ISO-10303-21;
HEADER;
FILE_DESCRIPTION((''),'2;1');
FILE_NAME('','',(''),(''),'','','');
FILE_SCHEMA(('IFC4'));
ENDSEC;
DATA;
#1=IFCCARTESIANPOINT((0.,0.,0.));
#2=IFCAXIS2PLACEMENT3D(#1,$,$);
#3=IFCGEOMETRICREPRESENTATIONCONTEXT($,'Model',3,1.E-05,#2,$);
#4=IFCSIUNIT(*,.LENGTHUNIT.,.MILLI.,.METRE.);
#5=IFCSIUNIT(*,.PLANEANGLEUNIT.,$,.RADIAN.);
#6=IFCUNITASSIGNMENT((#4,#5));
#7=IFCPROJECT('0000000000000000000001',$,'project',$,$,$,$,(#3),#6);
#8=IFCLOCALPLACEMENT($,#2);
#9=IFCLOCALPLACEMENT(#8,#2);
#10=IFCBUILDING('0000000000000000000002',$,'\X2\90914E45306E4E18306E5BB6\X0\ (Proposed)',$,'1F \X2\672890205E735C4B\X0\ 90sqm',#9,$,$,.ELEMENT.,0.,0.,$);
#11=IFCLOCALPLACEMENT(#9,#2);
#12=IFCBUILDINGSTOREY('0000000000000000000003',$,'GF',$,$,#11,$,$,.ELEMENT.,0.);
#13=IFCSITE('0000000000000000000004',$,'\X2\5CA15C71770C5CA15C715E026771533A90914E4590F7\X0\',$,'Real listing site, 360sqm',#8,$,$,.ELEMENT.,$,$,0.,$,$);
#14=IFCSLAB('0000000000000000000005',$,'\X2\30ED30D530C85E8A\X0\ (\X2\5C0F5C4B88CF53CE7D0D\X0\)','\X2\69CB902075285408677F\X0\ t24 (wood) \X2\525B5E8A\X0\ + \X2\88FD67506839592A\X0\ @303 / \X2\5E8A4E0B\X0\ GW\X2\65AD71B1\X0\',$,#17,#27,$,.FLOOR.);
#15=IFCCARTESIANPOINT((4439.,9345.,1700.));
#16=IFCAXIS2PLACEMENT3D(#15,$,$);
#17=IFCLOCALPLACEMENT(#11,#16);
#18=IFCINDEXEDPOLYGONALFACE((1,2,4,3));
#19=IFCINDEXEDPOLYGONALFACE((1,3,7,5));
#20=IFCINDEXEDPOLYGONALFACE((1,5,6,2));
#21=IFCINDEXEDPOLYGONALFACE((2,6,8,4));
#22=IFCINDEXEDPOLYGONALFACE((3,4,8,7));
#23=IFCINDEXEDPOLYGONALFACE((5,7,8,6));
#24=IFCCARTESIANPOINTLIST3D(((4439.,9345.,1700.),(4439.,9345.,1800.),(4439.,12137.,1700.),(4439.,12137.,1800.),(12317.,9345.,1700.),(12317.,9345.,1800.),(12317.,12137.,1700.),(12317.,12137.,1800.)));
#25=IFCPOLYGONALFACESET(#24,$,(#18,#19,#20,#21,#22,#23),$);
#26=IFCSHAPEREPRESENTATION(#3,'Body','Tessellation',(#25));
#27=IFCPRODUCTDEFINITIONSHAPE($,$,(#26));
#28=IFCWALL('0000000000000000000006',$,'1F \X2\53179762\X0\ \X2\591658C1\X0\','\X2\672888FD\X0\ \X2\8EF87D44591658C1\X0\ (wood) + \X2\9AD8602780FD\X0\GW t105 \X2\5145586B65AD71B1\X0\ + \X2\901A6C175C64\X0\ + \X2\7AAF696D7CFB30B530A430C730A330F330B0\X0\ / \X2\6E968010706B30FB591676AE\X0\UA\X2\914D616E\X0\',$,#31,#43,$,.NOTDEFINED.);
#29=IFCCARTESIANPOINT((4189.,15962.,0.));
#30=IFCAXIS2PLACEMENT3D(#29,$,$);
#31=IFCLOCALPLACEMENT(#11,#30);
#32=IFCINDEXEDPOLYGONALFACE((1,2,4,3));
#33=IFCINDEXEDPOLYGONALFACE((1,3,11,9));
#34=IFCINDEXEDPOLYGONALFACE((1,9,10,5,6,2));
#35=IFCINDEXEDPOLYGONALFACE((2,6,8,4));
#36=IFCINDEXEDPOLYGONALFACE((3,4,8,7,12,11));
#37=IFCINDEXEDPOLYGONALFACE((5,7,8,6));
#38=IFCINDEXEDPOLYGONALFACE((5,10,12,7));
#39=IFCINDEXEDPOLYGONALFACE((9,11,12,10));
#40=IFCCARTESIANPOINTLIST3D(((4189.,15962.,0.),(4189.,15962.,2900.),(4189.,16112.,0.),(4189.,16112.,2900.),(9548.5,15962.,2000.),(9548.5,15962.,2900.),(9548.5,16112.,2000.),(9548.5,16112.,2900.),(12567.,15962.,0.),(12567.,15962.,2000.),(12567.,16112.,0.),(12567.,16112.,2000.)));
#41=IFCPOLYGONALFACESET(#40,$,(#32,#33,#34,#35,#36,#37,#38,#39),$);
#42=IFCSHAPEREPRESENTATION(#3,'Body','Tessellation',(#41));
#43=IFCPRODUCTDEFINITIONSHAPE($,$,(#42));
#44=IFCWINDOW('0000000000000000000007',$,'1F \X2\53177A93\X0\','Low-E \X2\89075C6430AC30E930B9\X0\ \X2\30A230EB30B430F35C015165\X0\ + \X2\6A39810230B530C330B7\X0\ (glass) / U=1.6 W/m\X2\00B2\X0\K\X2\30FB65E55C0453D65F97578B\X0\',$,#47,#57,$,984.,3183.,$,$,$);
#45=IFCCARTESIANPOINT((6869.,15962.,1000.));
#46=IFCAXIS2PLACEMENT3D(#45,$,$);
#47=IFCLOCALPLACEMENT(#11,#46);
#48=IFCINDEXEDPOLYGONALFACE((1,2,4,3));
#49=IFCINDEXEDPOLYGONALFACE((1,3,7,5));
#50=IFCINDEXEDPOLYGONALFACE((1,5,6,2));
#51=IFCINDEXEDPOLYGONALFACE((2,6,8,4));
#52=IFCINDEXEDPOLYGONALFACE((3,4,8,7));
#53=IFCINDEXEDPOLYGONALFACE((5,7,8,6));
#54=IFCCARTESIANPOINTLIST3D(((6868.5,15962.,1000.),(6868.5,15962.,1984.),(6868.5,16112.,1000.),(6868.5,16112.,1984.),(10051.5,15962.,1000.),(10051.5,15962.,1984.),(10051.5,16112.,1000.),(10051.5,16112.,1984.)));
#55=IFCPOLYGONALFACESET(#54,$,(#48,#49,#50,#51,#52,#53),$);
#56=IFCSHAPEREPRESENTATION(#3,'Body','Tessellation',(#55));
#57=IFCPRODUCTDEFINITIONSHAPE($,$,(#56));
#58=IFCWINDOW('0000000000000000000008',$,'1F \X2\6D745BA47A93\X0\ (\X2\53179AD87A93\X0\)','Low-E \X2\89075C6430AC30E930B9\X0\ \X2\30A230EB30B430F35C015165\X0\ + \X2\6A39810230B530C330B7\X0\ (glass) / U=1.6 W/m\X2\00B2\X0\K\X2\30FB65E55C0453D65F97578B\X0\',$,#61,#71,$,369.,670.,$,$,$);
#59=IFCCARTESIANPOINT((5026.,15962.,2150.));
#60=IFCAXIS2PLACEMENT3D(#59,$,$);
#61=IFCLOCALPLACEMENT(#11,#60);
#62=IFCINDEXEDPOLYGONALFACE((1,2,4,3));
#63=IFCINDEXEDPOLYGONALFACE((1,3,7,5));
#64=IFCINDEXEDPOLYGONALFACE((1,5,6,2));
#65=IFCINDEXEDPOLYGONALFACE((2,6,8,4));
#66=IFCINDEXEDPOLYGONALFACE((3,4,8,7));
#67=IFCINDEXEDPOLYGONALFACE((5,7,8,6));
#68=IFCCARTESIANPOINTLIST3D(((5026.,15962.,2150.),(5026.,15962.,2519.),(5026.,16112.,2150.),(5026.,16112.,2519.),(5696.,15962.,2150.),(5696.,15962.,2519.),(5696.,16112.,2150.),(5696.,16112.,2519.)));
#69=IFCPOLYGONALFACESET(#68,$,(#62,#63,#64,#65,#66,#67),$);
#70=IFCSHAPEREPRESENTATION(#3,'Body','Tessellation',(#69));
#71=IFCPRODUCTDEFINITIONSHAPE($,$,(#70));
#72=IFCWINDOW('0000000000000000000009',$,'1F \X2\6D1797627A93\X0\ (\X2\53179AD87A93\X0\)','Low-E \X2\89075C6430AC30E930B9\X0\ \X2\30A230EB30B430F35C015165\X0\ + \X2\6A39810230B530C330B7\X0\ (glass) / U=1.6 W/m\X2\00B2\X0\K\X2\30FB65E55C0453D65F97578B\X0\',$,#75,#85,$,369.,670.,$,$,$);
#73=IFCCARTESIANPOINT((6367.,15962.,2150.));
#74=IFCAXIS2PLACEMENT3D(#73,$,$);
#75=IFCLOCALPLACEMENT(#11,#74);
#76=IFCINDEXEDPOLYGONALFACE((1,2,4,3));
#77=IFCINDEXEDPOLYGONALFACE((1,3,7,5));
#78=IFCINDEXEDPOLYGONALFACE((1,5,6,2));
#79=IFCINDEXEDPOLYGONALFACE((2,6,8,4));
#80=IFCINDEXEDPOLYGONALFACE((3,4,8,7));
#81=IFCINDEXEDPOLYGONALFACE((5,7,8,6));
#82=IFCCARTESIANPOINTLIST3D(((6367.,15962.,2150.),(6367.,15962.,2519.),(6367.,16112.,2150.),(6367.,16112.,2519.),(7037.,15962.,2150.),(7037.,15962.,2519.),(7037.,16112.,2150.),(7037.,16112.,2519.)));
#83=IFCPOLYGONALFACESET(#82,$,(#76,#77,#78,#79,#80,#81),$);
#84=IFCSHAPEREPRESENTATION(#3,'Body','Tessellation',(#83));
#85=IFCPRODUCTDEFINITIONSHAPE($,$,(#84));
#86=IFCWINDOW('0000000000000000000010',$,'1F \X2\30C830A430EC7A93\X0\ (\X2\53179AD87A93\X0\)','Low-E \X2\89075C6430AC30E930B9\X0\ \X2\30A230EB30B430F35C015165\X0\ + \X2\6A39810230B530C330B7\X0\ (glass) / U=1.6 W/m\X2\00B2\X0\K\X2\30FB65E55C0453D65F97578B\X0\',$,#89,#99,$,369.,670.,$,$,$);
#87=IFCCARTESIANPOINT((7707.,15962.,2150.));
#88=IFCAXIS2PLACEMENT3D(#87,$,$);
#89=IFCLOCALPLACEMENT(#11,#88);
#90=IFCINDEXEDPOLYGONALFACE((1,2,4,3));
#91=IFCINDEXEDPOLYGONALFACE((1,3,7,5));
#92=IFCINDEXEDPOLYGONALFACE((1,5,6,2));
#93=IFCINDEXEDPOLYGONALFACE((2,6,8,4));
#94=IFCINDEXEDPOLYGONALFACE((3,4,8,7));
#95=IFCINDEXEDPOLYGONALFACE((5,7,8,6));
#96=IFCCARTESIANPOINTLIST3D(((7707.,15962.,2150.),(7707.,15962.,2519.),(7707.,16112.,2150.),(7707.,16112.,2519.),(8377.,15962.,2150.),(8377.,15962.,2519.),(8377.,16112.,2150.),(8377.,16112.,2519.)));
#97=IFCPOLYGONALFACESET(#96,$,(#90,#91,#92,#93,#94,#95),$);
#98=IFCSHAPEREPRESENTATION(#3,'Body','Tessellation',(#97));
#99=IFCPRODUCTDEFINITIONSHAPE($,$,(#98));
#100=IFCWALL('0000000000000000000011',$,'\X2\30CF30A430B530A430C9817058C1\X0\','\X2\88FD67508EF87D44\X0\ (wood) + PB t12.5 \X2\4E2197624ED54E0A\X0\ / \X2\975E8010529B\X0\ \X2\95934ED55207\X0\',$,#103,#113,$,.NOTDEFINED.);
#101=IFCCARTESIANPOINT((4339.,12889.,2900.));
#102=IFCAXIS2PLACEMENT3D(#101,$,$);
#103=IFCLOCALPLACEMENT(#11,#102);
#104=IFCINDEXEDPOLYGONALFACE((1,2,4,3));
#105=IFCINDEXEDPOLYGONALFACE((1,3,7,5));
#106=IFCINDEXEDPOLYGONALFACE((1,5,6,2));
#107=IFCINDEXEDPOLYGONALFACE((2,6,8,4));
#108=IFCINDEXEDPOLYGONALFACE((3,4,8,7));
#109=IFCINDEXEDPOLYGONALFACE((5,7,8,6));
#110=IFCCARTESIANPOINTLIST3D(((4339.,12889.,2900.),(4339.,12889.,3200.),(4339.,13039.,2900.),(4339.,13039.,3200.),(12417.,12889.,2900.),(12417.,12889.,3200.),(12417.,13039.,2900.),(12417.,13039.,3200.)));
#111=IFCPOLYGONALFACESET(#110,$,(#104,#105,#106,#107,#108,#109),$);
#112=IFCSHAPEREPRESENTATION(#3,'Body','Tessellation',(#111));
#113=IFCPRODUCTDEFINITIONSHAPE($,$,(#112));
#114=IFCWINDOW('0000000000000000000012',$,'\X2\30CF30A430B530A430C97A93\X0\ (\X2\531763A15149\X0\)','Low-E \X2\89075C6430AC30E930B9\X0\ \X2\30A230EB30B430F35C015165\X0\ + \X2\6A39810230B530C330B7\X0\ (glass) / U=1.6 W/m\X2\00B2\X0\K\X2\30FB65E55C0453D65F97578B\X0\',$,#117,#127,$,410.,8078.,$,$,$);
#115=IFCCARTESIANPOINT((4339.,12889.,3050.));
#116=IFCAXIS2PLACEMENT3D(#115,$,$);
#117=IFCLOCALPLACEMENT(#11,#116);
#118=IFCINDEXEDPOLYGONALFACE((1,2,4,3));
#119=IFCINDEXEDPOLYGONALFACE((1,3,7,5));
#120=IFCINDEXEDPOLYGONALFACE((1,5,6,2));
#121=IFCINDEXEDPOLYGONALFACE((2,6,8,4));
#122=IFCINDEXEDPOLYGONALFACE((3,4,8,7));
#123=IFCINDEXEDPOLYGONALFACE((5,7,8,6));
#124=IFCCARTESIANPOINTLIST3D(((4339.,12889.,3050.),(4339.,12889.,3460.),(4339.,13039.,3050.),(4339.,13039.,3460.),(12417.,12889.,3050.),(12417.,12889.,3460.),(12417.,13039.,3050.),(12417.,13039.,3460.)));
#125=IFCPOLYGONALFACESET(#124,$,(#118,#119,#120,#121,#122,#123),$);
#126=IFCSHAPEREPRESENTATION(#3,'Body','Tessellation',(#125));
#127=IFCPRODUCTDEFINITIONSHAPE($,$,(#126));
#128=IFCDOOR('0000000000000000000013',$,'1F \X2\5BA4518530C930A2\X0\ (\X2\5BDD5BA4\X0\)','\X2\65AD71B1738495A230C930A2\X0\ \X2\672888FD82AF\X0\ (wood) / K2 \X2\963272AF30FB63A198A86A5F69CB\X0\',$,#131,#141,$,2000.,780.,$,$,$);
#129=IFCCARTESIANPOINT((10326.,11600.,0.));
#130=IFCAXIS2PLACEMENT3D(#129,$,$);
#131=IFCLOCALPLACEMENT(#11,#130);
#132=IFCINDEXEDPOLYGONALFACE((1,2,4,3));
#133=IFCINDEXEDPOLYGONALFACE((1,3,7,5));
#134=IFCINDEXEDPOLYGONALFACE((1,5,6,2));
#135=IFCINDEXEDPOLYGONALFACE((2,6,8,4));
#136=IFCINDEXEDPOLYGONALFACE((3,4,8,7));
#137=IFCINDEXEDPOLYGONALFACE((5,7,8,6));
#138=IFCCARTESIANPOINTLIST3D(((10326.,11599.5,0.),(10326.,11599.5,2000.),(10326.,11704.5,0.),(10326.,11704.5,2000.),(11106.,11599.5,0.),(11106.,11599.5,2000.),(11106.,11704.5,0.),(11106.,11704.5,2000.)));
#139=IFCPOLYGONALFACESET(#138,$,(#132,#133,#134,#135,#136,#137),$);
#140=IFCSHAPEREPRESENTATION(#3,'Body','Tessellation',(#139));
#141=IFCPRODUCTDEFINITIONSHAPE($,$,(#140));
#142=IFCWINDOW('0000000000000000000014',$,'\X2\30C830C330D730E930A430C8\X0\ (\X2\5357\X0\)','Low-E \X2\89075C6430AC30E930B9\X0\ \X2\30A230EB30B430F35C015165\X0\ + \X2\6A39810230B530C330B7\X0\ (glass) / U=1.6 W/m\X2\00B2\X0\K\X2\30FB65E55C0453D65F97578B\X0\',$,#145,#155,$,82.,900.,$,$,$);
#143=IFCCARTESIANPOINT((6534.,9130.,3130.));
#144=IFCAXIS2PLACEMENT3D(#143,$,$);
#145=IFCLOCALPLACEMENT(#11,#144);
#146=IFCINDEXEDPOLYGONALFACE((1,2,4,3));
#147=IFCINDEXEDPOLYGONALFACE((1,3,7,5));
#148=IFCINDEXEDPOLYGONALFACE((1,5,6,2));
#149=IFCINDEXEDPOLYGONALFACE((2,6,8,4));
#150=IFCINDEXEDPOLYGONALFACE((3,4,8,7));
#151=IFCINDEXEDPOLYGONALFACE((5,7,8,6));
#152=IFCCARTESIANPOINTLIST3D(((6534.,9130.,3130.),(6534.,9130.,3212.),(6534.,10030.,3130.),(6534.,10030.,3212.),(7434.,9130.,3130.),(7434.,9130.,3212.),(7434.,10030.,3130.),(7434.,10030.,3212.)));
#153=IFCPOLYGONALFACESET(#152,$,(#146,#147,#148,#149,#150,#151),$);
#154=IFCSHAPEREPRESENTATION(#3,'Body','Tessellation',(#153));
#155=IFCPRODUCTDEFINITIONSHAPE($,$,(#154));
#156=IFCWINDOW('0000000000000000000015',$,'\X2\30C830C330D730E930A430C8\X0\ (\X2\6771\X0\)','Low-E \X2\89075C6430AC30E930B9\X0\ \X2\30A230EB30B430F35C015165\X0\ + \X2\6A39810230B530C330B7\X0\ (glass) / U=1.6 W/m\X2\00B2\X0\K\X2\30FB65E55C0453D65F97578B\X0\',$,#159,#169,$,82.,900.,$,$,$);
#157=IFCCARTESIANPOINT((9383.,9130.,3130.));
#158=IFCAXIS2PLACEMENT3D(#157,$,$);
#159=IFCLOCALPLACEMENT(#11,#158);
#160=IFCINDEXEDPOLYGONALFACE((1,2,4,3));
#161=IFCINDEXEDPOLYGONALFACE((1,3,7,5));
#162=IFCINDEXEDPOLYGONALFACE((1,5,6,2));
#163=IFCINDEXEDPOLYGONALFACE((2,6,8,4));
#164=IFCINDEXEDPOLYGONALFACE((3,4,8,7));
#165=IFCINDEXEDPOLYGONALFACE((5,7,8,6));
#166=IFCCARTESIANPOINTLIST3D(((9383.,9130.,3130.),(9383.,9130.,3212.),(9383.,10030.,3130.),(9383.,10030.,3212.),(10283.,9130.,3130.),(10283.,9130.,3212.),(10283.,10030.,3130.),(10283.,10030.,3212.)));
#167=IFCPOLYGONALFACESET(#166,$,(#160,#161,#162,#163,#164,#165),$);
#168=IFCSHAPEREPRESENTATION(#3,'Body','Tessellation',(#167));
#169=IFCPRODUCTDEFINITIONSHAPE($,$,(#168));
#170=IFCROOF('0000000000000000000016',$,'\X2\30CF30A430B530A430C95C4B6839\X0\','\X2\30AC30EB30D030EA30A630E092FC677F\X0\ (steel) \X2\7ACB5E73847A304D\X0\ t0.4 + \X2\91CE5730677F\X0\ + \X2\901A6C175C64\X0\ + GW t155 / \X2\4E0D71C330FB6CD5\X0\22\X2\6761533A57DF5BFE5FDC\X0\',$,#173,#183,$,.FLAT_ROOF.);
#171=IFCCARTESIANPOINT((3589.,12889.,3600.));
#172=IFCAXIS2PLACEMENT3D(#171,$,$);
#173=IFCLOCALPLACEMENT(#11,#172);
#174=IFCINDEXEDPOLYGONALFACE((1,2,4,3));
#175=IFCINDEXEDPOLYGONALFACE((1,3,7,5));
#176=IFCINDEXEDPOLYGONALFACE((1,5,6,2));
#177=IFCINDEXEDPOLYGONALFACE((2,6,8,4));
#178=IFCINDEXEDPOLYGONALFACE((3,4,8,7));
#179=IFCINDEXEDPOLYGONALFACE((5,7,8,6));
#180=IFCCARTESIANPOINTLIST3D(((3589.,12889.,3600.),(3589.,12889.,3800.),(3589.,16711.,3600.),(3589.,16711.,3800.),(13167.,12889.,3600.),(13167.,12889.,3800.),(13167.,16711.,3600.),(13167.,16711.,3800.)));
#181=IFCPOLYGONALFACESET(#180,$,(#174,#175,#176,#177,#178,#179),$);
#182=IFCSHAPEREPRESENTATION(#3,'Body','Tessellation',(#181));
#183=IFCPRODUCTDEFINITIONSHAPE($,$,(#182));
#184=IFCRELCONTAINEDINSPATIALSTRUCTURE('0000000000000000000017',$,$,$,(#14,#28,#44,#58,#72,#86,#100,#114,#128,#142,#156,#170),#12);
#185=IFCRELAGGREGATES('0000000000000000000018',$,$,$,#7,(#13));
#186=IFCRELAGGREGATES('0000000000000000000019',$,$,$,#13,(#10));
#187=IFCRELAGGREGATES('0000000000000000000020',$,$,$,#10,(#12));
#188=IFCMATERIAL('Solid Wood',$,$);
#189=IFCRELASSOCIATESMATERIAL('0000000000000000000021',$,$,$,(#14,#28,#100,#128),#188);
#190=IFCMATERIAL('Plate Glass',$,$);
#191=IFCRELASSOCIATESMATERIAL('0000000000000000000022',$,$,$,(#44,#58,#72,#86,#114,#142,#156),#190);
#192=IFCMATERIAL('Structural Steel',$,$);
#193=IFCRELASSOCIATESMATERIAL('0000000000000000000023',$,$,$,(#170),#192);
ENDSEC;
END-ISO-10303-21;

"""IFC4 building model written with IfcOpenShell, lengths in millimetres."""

from ifc_helpers import new_model, si_unit, frame, frame_2d, origin, place, context, project, spatial, rectangle, extrude, material, element, fill, save


model = new_model("IFC4")

# Units and contexts
model_context = context("Model", 3, precision=1e-05, world=origin())
ifc_project = project(units=[si_unit("LENGTHUNIT", "METRE", prefix="MILLI"), si_unit("PLANEANGLEUNIT", "RADIAN")], contexts=[model_context])

# Site, building, storey
site_placement = place(None, origin())
site = spatial("IfcSite", under=ifc_project, at=site_placement, Name="岡山県岡山市東区邑久郷", ObjectType="Real listing site, 360sqm", CompositionType="ELEMENT", RefElevation=0.0)
building_placement = place(site_placement, origin())
building = spatial("IfcBuilding", under=site, at=building_placement, Name="邑久の丘の家 (Proposed)", ObjectType="1F 木造平屋 90sqm", CompositionType="ELEMENT", ElevationOfRefHeight=0.0, ElevationOfTerrain=0.0)
storey_placement = place(building_placement, origin())
storey = spatial("IfcBuildingStorey", under=building, at=storey_placement, Name="GF", CompositionType="ELEMENT", Elevation=0.0)

# Slab
ifc_material_1 = material(Name="Solid Wood")
slab_placement = place(storey_placement, frame((4439.0, 9345.0, 1700.0)))
element("IfcSlab", 1, at=slab_placement, inside=storey, material=ifc_material_1, Name="ロフト床 (小屋裏収納)", Description="構造用合板 t24 (wood) 剛床 + 製材根太 @303 / 床下 GW断熱", PredefinedType="FLOOR", context=model_context, shape_type="SweptSolid", body=[
    extrude(rectangle(XDim=7878.0, YDim=2792.0, at=frame_2d((3939.0, 1396.0))), frame((4439.0, 9345.0, 1700.0)), (0.0, 0.0, 1.0), 100.0),
])

# Wall, openings, windows
wall_1_placement = place(storey_placement, frame((4189.0, 15962.0, 0.0)))
wall_1 = element("IfcWall", 2, at=wall_1_placement, inside=storey, material=ifc_material_1, Name="1F 北面 外壁", Description="木製 軸組外壁 (wood) + 高性能GW t105 充填断熱 + 通気層 + 窯業系サイディング / 準耐火・外皮UA配慮", PredefinedType="NOTDEFINED", context=model_context, shape_type="SweptSolid", body=[
    extrude(rectangle(XDim=8378.0, YDim=150.0, at=frame_2d((4189.0, 75.0))), frame((4189.0, 15962.0, 0.0)), (0.0, 0.0, 1.0), 2900.0),
])
opening_1_placement = place(storey_placement, frame((6869.0, 15962.0, 1000.0)))
opening_1 = element("IfcOpeningElement", 3, at=opening_1_placement, cuts=wall_1, PredefinedType="NOTDEFINED", context=model_context, shape_type="SweptSolid", body=[
    extrude(rectangle(XDim=3183.0, YDim=150.0, at=frame_2d((1591.0, 75.0))), frame((6869.0, 15962.0, 1000.0)), (0.0, 0.0, 1.0), 984.0),
])
opening_2_placement = place(storey_placement, frame((5026.0, 15962.0, 2150.0)))
opening_2 = element("IfcOpeningElement", 4, at=opening_2_placement, cuts=wall_1, PredefinedType="NOTDEFINED", context=model_context, shape_type="SweptSolid", body=[
    extrude(rectangle(XDim=670.0, YDim=150.0, at=frame_2d((335.0, 75.0))), frame((5026.0, 15962.0, 2150.0)), (0.0, 0.0, 1.0), 369.0),
])
opening_3_placement = place(storey_placement, frame((6367.0, 15962.0, 2150.0)))
opening_3 = element("IfcOpeningElement", 5, at=opening_3_placement, cuts=wall_1, PredefinedType="NOTDEFINED", context=model_context, shape_type="SweptSolid", body=[
    extrude(rectangle(XDim=670.0, YDim=150.0, at=frame_2d((335.0, 75.0))), frame((6367.0, 15962.0, 2150.0)), (0.0, 0.0, 1.0), 369.0),
])
opening_4_placement = place(storey_placement, frame((7707.0, 15962.0, 2150.0)))
opening_4 = element("IfcOpeningElement", 6, at=opening_4_placement, cuts=wall_1, PredefinedType="NOTDEFINED", context=model_context, shape_type="SweptSolid", body=[
    extrude(rectangle(XDim=670.0, YDim=150.0, at=frame_2d((335.0, 75.0))), frame((7707.0, 15962.0, 2150.0)), (0.0, 0.0, 1.0), 369.0),
])
ifc_material_2 = material(Name="Plate Glass")
window_1_placement = place(storey_placement, frame((6869.0, 15962.0, 1000.0)))
window_1 = element("IfcWindow", 7, at=window_1_placement, inside=storey, material=ifc_material_2, Name="1F 北窓", Description="Low-E 複層ガラス アルゴン封入 + 樹脂サッシ (glass) / U=1.6 W/m²K・日射取得型", OverallHeight=984.0, OverallWidth=3183.0, context=model_context, shape_type="SweptSolid", body=[
    extrude(rectangle(XDim=3183.0, YDim=150.0, at=frame_2d((1591.0, 75.0))), frame((6869.0, 15962.0, 1000.0)), (0.0, 0.0, 1.0), 984.0),
])
fill(opening_1, window_1)
window_2_placement = place(storey_placement, frame((5026.0, 15962.0, 2150.0)))
window_2 = element("IfcWindow", 8, at=window_2_placement, inside=storey, material=ifc_material_2, Name="1F 浴室窓 (北高窓)", Description="Low-E 複層ガラス アルゴン封入 + 樹脂サッシ (glass) / U=1.6 W/m²K・日射取得型", OverallHeight=369.0, OverallWidth=670.0, context=model_context, shape_type="SweptSolid", body=[
    extrude(rectangle(XDim=670.0, YDim=150.0, at=frame_2d((335.0, 75.0))), frame((5026.0, 15962.0, 2150.0)), (0.0, 0.0, 1.0), 369.0),
])
fill(opening_2, window_2)
window_3_placement = place(storey_placement, frame((6367.0, 15962.0, 2150.0)))
window_3 = element("IfcWindow", 9, at=window_3_placement, inside=storey, material=ifc_material_2, Name="1F 洗面窓 (北高窓)", Description="Low-E 複層ガラス アルゴン封入 + 樹脂サッシ (glass) / U=1.6 W/m²K・日射取得型", OverallHeight=369.0, OverallWidth=670.0, context=model_context, shape_type="SweptSolid", body=[
    extrude(rectangle(XDim=670.0, YDim=150.0, at=frame_2d((335.0, 75.0))), frame((6367.0, 15962.0, 2150.0)), (0.0, 0.0, 1.0), 369.0),
])
fill(opening_3, window_3)
window_4_placement = place(storey_placement, frame((7707.0, 15962.0, 2150.0)))
window_4 = element("IfcWindow", 10, at=window_4_placement, inside=storey, material=ifc_material_2, Name="1F トイレ窓 (北高窓)", Description="Low-E 複層ガラス アルゴン封入 + 樹脂サッシ (glass) / U=1.6 W/m²K・日射取得型", OverallHeight=369.0, OverallWidth=670.0, context=model_context, shape_type="SweptSolid", body=[
    extrude(rectangle(XDim=670.0, YDim=150.0, at=frame_2d((335.0, 75.0))), frame((7707.0, 15962.0, 2150.0)), (0.0, 0.0, 1.0), 369.0),
])
fill(opening_4, window_4)

# Wall, opening, window
wall_2_placement = place(storey_placement, frame((4339.0, 12889.0, 2900.0)))
wall_2 = element("IfcWall", 11, at=wall_2_placement, inside=storey, material=ifc_material_1, Name="ハイサイド腰壁", Description="製材軸組 (wood) + PB t12.5 両面仕上 / 非耐力 間仕切", PredefinedType="NOTDEFINED", context=model_context, shape_type="SweptSolid", body=[
    extrude(rectangle(XDim=8078.0, YDim=150.0, at=frame_2d((4039.0, 75.0))), frame((4339.0, 12889.0, 2900.0)), (0.0, 0.0, 1.0), 700.0),
])
opening_5_placement = place(storey_placement, frame((4339.0, 12889.0, 3050.0)))
opening_5 = element("IfcOpeningElement", 12, at=opening_5_placement, cuts=wall_2, PredefinedType="NOTDEFINED", context=model_context, shape_type="SweptSolid", body=[
    extrude(rectangle(XDim=8078.0, YDim=150.0, at=frame_2d((4039.0, 75.0))), frame((4339.0, 12889.0, 3050.0)), (0.0, 0.0, 1.0), 410.0),
])
window_5_placement = place(storey_placement, frame((4339.0, 12889.0, 3050.0)))
window_5 = element("IfcWindow", 13, at=window_5_placement, inside=storey, material=ifc_material_2, Name="ハイサイド窓 (北採光)", Description="Low-E 複層ガラス アルゴン封入 + 樹脂サッシ (glass) / U=1.6 W/m²K・日射取得型", OverallHeight=410.0, OverallWidth=8078.0, context=model_context, shape_type="SweptSolid", body=[
    extrude(rectangle(XDim=8078.0, YDim=150.0, at=frame_2d((4039.0, 75.0))), frame((4339.0, 12889.0, 3050.0)), (0.0, 0.0, 1.0), 410.0),
])
fill(opening_5, window_5)

# Door
door_1_placement = place(storey_placement, frame((10326.0, 11600.0, 0.0)))
element("IfcDoor", 14, at=door_1_placement, inside=storey, material=ifc_material_1, Name="1F 室内ドア (寝室)", Description="断熱玄関ドア 木製芯 (wood) / K2 防犯・採風機構", OverallHeight=2000.0, OverallWidth=780.0, context=model_context, shape_type="SweptSolid", body=[
    extrude(rectangle(XDim=780.0, YDim=105.0, at=frame_2d((390.0, 52.0))), frame((10326.0, 11600.0, 0.0)), (0.0, 0.0, 1.0), 2000.0),
])

# Windows
window_6_placement = place(storey_placement, frame((6534.0, 9130.0, 3130.0)))
element("IfcWindow", 15, at=window_6_placement, inside=storey, material=ifc_material_2, Name="トップライト (南)", Description="Low-E 複層ガラス アルゴン封入 + 樹脂サッシ (glass) / U=1.6 W/m²K・日射取得型", OverallHeight=82.0, OverallWidth=900.0, context=model_context, shape_type="SweptSolid", body=[
    extrude(rectangle(XDim=900.0, YDim=900.0, at=frame_2d((450.0, 450.0))), frame((6534.0, 9130.0, 3130.0)), (0.0, 0.0, 1.0), 82.0),
])
window_7_placement = place(storey_placement, frame((9383.0, 9130.0, 3130.0)))
element("IfcWindow", 16, at=window_7_placement, inside=storey, material=ifc_material_2, Name="トップライト (東)", Description="Low-E 複層ガラス アルゴン封入 + 樹脂サッシ (glass) / U=1.6 W/m²K・日射取得型", OverallHeight=82.0, OverallWidth=900.0, context=model_context, shape_type="SweptSolid", body=[
    extrude(rectangle(XDim=900.0, YDim=900.0, at=frame_2d((450.0, 450.0))), frame((9383.0, 9130.0, 3130.0)), (0.0, 0.0, 1.0), 82.0),
])

# Roof
ifc_material_3 = material(Name="Structural Steel")
roof_placement = place(storey_placement, frame((3589.0, 12889.0, 3600.0)))
element("IfcRoof", 17, at=roof_placement, inside=storey, material=ifc_material_3, Name="ハイサイド屋根", Description="ガルバリウム鋼板 (steel) 立平葺き t0.4 + 野地板 + 通気層 + GW t155 / 不燃・法22条区域対応", PredefinedType="FLAT_ROOF", context=model_context, shape_type="SweptSolid", body=[
    extrude(rectangle(XDim=9578.0, YDim=3822.0, at=frame_2d((4789.0, 1911.0))), frame((3589.0, 12889.0, 3600.0)), (0.0, 0.0, 1.0), 200.0),
])

save(model, "model.ifc")
